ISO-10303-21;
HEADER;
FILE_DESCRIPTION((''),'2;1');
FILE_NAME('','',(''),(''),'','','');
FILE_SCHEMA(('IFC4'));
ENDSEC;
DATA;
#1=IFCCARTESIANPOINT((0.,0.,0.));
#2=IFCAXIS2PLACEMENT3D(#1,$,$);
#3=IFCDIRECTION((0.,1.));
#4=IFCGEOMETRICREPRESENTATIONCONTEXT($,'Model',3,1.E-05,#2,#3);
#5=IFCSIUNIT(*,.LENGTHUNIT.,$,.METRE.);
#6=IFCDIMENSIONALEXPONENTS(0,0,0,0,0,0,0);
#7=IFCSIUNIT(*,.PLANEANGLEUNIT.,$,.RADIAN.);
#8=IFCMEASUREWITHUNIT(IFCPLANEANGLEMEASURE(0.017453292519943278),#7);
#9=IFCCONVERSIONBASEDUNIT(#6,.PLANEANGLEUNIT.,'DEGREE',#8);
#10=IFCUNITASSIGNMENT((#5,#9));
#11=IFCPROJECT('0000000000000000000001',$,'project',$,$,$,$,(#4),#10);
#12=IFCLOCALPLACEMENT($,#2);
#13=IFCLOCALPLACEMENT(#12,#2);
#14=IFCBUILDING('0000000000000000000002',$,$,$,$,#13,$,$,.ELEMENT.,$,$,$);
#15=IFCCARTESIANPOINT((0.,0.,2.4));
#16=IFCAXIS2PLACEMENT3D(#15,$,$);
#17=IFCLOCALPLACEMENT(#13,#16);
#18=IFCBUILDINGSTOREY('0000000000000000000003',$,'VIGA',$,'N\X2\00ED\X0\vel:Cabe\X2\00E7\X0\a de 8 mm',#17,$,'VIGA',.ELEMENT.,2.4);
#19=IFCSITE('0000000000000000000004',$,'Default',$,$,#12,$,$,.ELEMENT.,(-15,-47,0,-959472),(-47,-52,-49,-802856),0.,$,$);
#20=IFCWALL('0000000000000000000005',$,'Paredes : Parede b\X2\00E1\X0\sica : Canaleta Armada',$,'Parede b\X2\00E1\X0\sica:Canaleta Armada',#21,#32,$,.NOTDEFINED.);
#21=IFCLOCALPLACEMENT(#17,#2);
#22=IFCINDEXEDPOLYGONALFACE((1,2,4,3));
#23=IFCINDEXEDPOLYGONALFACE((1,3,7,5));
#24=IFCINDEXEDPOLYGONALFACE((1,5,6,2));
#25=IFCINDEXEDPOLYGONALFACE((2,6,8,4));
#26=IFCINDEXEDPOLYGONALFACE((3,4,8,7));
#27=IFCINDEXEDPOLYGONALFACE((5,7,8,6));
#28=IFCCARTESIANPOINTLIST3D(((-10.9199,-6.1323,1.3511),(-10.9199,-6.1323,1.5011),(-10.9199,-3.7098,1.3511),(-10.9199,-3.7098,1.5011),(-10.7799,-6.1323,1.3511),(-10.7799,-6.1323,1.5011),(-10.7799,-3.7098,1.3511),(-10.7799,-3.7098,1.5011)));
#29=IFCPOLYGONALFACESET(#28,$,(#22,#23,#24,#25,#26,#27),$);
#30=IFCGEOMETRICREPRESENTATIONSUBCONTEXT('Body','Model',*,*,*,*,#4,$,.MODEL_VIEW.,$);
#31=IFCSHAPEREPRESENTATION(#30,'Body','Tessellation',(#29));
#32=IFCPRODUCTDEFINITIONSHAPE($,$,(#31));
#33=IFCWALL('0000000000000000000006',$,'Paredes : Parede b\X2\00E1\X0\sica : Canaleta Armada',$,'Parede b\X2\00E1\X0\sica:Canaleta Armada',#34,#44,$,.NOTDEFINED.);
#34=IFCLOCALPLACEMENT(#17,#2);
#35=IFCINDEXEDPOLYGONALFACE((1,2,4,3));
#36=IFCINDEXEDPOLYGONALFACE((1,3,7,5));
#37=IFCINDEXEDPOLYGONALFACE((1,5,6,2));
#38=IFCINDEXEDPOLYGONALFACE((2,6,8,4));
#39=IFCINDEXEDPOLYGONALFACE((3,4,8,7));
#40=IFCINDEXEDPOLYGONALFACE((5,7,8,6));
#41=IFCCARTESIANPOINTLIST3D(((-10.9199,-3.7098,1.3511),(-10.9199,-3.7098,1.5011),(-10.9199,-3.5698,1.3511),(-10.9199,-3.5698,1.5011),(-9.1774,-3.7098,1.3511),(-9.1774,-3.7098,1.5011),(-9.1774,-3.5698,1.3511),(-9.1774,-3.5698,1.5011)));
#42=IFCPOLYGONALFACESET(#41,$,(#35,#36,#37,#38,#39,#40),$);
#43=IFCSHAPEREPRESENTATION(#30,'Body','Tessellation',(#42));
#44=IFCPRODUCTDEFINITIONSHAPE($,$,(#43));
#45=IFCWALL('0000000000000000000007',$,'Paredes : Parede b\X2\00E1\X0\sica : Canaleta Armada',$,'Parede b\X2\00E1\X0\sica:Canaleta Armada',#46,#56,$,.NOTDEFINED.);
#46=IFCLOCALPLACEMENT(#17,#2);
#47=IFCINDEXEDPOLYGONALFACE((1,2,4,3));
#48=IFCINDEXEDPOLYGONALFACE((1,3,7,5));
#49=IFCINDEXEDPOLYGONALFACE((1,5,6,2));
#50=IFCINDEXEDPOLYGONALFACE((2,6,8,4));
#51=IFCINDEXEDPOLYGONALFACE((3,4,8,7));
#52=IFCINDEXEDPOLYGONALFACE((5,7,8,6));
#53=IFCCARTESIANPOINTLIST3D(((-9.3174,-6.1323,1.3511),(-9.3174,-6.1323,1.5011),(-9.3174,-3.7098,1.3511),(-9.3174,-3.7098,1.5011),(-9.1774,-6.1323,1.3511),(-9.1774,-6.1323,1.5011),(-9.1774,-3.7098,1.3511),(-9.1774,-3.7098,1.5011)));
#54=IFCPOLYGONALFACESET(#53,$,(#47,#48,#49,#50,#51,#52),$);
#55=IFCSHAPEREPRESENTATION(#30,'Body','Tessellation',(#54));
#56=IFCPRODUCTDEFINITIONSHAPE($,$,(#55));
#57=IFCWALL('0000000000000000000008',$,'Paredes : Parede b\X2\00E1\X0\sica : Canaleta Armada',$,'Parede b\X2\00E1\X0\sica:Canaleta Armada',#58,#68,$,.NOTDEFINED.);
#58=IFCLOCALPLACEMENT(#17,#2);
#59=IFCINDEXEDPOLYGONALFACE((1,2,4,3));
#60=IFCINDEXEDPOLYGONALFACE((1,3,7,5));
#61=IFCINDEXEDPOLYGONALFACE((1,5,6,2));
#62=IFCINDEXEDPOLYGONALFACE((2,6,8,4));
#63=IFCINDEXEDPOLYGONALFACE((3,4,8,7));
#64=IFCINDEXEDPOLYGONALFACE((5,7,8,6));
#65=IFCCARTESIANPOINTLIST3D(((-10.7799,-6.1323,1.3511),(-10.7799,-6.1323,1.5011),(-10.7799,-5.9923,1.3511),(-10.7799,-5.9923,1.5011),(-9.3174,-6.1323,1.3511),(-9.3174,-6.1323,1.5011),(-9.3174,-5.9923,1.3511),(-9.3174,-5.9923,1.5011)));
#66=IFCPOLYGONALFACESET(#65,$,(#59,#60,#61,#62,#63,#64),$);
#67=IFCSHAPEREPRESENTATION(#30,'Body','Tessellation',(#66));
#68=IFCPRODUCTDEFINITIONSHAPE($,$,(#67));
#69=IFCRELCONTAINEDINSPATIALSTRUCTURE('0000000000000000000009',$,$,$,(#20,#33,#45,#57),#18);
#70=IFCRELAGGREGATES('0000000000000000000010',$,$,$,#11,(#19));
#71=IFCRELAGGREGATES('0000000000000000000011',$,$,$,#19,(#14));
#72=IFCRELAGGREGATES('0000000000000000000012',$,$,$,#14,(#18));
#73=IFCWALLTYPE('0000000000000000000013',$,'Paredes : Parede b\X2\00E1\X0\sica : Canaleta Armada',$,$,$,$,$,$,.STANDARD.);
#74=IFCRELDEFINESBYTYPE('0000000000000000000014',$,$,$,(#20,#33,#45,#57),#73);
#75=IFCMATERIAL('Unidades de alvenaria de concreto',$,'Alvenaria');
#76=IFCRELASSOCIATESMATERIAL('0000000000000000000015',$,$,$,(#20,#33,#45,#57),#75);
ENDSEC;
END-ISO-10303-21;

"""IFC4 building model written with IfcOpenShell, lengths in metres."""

from ifc_helpers import new_model, entity, si_unit, converted_unit, direction, frame, origin, place, context, subcontext, project, spatial, indexed_curve, outline, extrude, material, type_object, element, save


model = new_model("IFC4")

# Units and contexts
model_context = context("Model", 3, precision=1e-05, world=origin(), true_north=direction((0.0, 1.0)))
body_context = subcontext(model_context, "Body", "Model", "MODEL_VIEW")
ifc_project = project(units=[si_unit("LENGTHUNIT", "METRE"), converted_unit("PLANEANGLEUNIT", "DEGREE", entity("IfcPlaneAngleMeasure", 0.017453292519943278), si_unit("PLANEANGLEUNIT", "RADIAN"), dimensions=[0, 0, 0, 0, 0, 0, 0])], contexts=[model_context])

# Site, building, storey
site_placement = place(None, origin())
site = spatial("IfcSite", under=ifc_project, at=site_placement, Name="Default", CompositionType="ELEMENT", RefLatitude=(-15, -47, 0, -959472), RefLongitude=(-47, -52, -49, -802856), RefElevation=0.0)
building_placement = place(site_placement, origin())
building = spatial("IfcBuilding", under=site, at=building_placement, CompositionType="ELEMENT")
storey_placement = place(building_placement, frame((0.0, 0.0, 2.4)))
storey = spatial("IfcBuildingStorey", under=building, at=storey_placement, Name="VIGA", ObjectType="Nível:Cabeça de 8 mm", LongName="VIGA", CompositionType="ELEMENT", Elevation=2.4)

# Walls
ifc_material_1 = material(Name="Unidades de alvenaria de concreto", Category="Alvenaria")
wall_type_1 = type_object("IfcWallType", Name="Paredes : Parede básica : Canaleta Armada", PredefinedType="STANDARD")
wall_1_placement = place(storey_placement, frame((-10.8499, -3.7098, 1.3511), z_axis=(0.0, 0.0, 1.0), x_axis=(0.0, -1.0, 0.0)))
element("IfcWall", 1, at=wall_1_placement, inside=storey, type_object=wall_type_1, material=ifc_material_1, Name="Paredes : Parede básica : Canaleta Armada", ObjectType="Parede básica:Canaleta Armada", PredefinedType="NOTDEFINED", context=body_context, shape_type="SweptSolid", body=[
    extrude(outline(indexed_curve([(2.4225, 0.07), (0.0, 0.07), (0.0, -0.07), (2.4225, -0.07), (2.4225, 0.07)], self_intersect=False)), origin(), (0.0, 0.0, 1.0), 0.15),
])
wall_2_placement = place(storey_placement, frame((-10.9199, -3.6398, 1.3511)))
element("IfcWall", 2, at=wall_2_placement, inside=storey, type_object=wall_type_1, material=ifc_material_1, Name="Paredes : Parede básica : Canaleta Armada", ObjectType="Parede básica:Canaleta Armada", PredefinedType="NOTDEFINED", context=body_context, shape_type="SweptSolid", body=[
    extrude(outline(indexed_curve([(1.7425, 0.07), (0.0, 0.07), (0.0, -0.07), (1.7425, -0.07), (1.7425, 0.07)], self_intersect=False)), origin(), (0.0, 0.0, 1.0), 0.15),
])
wall_3_placement = place(storey_placement, frame((-9.2474, -3.7098, 1.3511), z_axis=(0.0, 0.0, 1.0), x_axis=(0.0, -1.0, 0.0)))
element("IfcWall", 3, at=wall_3_placement, inside=storey, type_object=wall_type_1, material=ifc_material_1, Name="Paredes : Parede básica : Canaleta Armada", ObjectType="Parede básica:Canaleta Armada", PredefinedType="NOTDEFINED", context=body_context, shape_type="SweptSolid", body=[
    extrude(outline(indexed_curve([(2.4225, 0.07), (0.0, 0.07), (0.0, -0.07), (2.4225, -0.07), (2.4225, 0.07)], self_intersect=False)), origin(), (0.0, 0.0, 1.0), 0.15),
])
wall_4_placement = place(storey_placement, frame((-9.3174, -6.0623, 1.3511), z_axis=(0.0, 0.0, 1.0), x_axis=(-1.0, 0.0, 0.0)))
element("IfcWall", 4, at=wall_4_placement, inside=storey, type_object=wall_type_1, material=ifc_material_1, Name="Paredes : Parede básica : Canaleta Armada", ObjectType="Parede básica:Canaleta Armada", PredefinedType="NOTDEFINED", context=body_context, shape_type="SweptSolid", body=[
    extrude(outline(indexed_curve([(1.4625, 0.07), (0.0, 0.07), (0.0, -0.07), (1.4625, -0.07), (1.4625, 0.07)], self_intersect=False)), origin(), (0.0, 0.0, 1.0), 0.15),
])

save(model, "model.ifc")
